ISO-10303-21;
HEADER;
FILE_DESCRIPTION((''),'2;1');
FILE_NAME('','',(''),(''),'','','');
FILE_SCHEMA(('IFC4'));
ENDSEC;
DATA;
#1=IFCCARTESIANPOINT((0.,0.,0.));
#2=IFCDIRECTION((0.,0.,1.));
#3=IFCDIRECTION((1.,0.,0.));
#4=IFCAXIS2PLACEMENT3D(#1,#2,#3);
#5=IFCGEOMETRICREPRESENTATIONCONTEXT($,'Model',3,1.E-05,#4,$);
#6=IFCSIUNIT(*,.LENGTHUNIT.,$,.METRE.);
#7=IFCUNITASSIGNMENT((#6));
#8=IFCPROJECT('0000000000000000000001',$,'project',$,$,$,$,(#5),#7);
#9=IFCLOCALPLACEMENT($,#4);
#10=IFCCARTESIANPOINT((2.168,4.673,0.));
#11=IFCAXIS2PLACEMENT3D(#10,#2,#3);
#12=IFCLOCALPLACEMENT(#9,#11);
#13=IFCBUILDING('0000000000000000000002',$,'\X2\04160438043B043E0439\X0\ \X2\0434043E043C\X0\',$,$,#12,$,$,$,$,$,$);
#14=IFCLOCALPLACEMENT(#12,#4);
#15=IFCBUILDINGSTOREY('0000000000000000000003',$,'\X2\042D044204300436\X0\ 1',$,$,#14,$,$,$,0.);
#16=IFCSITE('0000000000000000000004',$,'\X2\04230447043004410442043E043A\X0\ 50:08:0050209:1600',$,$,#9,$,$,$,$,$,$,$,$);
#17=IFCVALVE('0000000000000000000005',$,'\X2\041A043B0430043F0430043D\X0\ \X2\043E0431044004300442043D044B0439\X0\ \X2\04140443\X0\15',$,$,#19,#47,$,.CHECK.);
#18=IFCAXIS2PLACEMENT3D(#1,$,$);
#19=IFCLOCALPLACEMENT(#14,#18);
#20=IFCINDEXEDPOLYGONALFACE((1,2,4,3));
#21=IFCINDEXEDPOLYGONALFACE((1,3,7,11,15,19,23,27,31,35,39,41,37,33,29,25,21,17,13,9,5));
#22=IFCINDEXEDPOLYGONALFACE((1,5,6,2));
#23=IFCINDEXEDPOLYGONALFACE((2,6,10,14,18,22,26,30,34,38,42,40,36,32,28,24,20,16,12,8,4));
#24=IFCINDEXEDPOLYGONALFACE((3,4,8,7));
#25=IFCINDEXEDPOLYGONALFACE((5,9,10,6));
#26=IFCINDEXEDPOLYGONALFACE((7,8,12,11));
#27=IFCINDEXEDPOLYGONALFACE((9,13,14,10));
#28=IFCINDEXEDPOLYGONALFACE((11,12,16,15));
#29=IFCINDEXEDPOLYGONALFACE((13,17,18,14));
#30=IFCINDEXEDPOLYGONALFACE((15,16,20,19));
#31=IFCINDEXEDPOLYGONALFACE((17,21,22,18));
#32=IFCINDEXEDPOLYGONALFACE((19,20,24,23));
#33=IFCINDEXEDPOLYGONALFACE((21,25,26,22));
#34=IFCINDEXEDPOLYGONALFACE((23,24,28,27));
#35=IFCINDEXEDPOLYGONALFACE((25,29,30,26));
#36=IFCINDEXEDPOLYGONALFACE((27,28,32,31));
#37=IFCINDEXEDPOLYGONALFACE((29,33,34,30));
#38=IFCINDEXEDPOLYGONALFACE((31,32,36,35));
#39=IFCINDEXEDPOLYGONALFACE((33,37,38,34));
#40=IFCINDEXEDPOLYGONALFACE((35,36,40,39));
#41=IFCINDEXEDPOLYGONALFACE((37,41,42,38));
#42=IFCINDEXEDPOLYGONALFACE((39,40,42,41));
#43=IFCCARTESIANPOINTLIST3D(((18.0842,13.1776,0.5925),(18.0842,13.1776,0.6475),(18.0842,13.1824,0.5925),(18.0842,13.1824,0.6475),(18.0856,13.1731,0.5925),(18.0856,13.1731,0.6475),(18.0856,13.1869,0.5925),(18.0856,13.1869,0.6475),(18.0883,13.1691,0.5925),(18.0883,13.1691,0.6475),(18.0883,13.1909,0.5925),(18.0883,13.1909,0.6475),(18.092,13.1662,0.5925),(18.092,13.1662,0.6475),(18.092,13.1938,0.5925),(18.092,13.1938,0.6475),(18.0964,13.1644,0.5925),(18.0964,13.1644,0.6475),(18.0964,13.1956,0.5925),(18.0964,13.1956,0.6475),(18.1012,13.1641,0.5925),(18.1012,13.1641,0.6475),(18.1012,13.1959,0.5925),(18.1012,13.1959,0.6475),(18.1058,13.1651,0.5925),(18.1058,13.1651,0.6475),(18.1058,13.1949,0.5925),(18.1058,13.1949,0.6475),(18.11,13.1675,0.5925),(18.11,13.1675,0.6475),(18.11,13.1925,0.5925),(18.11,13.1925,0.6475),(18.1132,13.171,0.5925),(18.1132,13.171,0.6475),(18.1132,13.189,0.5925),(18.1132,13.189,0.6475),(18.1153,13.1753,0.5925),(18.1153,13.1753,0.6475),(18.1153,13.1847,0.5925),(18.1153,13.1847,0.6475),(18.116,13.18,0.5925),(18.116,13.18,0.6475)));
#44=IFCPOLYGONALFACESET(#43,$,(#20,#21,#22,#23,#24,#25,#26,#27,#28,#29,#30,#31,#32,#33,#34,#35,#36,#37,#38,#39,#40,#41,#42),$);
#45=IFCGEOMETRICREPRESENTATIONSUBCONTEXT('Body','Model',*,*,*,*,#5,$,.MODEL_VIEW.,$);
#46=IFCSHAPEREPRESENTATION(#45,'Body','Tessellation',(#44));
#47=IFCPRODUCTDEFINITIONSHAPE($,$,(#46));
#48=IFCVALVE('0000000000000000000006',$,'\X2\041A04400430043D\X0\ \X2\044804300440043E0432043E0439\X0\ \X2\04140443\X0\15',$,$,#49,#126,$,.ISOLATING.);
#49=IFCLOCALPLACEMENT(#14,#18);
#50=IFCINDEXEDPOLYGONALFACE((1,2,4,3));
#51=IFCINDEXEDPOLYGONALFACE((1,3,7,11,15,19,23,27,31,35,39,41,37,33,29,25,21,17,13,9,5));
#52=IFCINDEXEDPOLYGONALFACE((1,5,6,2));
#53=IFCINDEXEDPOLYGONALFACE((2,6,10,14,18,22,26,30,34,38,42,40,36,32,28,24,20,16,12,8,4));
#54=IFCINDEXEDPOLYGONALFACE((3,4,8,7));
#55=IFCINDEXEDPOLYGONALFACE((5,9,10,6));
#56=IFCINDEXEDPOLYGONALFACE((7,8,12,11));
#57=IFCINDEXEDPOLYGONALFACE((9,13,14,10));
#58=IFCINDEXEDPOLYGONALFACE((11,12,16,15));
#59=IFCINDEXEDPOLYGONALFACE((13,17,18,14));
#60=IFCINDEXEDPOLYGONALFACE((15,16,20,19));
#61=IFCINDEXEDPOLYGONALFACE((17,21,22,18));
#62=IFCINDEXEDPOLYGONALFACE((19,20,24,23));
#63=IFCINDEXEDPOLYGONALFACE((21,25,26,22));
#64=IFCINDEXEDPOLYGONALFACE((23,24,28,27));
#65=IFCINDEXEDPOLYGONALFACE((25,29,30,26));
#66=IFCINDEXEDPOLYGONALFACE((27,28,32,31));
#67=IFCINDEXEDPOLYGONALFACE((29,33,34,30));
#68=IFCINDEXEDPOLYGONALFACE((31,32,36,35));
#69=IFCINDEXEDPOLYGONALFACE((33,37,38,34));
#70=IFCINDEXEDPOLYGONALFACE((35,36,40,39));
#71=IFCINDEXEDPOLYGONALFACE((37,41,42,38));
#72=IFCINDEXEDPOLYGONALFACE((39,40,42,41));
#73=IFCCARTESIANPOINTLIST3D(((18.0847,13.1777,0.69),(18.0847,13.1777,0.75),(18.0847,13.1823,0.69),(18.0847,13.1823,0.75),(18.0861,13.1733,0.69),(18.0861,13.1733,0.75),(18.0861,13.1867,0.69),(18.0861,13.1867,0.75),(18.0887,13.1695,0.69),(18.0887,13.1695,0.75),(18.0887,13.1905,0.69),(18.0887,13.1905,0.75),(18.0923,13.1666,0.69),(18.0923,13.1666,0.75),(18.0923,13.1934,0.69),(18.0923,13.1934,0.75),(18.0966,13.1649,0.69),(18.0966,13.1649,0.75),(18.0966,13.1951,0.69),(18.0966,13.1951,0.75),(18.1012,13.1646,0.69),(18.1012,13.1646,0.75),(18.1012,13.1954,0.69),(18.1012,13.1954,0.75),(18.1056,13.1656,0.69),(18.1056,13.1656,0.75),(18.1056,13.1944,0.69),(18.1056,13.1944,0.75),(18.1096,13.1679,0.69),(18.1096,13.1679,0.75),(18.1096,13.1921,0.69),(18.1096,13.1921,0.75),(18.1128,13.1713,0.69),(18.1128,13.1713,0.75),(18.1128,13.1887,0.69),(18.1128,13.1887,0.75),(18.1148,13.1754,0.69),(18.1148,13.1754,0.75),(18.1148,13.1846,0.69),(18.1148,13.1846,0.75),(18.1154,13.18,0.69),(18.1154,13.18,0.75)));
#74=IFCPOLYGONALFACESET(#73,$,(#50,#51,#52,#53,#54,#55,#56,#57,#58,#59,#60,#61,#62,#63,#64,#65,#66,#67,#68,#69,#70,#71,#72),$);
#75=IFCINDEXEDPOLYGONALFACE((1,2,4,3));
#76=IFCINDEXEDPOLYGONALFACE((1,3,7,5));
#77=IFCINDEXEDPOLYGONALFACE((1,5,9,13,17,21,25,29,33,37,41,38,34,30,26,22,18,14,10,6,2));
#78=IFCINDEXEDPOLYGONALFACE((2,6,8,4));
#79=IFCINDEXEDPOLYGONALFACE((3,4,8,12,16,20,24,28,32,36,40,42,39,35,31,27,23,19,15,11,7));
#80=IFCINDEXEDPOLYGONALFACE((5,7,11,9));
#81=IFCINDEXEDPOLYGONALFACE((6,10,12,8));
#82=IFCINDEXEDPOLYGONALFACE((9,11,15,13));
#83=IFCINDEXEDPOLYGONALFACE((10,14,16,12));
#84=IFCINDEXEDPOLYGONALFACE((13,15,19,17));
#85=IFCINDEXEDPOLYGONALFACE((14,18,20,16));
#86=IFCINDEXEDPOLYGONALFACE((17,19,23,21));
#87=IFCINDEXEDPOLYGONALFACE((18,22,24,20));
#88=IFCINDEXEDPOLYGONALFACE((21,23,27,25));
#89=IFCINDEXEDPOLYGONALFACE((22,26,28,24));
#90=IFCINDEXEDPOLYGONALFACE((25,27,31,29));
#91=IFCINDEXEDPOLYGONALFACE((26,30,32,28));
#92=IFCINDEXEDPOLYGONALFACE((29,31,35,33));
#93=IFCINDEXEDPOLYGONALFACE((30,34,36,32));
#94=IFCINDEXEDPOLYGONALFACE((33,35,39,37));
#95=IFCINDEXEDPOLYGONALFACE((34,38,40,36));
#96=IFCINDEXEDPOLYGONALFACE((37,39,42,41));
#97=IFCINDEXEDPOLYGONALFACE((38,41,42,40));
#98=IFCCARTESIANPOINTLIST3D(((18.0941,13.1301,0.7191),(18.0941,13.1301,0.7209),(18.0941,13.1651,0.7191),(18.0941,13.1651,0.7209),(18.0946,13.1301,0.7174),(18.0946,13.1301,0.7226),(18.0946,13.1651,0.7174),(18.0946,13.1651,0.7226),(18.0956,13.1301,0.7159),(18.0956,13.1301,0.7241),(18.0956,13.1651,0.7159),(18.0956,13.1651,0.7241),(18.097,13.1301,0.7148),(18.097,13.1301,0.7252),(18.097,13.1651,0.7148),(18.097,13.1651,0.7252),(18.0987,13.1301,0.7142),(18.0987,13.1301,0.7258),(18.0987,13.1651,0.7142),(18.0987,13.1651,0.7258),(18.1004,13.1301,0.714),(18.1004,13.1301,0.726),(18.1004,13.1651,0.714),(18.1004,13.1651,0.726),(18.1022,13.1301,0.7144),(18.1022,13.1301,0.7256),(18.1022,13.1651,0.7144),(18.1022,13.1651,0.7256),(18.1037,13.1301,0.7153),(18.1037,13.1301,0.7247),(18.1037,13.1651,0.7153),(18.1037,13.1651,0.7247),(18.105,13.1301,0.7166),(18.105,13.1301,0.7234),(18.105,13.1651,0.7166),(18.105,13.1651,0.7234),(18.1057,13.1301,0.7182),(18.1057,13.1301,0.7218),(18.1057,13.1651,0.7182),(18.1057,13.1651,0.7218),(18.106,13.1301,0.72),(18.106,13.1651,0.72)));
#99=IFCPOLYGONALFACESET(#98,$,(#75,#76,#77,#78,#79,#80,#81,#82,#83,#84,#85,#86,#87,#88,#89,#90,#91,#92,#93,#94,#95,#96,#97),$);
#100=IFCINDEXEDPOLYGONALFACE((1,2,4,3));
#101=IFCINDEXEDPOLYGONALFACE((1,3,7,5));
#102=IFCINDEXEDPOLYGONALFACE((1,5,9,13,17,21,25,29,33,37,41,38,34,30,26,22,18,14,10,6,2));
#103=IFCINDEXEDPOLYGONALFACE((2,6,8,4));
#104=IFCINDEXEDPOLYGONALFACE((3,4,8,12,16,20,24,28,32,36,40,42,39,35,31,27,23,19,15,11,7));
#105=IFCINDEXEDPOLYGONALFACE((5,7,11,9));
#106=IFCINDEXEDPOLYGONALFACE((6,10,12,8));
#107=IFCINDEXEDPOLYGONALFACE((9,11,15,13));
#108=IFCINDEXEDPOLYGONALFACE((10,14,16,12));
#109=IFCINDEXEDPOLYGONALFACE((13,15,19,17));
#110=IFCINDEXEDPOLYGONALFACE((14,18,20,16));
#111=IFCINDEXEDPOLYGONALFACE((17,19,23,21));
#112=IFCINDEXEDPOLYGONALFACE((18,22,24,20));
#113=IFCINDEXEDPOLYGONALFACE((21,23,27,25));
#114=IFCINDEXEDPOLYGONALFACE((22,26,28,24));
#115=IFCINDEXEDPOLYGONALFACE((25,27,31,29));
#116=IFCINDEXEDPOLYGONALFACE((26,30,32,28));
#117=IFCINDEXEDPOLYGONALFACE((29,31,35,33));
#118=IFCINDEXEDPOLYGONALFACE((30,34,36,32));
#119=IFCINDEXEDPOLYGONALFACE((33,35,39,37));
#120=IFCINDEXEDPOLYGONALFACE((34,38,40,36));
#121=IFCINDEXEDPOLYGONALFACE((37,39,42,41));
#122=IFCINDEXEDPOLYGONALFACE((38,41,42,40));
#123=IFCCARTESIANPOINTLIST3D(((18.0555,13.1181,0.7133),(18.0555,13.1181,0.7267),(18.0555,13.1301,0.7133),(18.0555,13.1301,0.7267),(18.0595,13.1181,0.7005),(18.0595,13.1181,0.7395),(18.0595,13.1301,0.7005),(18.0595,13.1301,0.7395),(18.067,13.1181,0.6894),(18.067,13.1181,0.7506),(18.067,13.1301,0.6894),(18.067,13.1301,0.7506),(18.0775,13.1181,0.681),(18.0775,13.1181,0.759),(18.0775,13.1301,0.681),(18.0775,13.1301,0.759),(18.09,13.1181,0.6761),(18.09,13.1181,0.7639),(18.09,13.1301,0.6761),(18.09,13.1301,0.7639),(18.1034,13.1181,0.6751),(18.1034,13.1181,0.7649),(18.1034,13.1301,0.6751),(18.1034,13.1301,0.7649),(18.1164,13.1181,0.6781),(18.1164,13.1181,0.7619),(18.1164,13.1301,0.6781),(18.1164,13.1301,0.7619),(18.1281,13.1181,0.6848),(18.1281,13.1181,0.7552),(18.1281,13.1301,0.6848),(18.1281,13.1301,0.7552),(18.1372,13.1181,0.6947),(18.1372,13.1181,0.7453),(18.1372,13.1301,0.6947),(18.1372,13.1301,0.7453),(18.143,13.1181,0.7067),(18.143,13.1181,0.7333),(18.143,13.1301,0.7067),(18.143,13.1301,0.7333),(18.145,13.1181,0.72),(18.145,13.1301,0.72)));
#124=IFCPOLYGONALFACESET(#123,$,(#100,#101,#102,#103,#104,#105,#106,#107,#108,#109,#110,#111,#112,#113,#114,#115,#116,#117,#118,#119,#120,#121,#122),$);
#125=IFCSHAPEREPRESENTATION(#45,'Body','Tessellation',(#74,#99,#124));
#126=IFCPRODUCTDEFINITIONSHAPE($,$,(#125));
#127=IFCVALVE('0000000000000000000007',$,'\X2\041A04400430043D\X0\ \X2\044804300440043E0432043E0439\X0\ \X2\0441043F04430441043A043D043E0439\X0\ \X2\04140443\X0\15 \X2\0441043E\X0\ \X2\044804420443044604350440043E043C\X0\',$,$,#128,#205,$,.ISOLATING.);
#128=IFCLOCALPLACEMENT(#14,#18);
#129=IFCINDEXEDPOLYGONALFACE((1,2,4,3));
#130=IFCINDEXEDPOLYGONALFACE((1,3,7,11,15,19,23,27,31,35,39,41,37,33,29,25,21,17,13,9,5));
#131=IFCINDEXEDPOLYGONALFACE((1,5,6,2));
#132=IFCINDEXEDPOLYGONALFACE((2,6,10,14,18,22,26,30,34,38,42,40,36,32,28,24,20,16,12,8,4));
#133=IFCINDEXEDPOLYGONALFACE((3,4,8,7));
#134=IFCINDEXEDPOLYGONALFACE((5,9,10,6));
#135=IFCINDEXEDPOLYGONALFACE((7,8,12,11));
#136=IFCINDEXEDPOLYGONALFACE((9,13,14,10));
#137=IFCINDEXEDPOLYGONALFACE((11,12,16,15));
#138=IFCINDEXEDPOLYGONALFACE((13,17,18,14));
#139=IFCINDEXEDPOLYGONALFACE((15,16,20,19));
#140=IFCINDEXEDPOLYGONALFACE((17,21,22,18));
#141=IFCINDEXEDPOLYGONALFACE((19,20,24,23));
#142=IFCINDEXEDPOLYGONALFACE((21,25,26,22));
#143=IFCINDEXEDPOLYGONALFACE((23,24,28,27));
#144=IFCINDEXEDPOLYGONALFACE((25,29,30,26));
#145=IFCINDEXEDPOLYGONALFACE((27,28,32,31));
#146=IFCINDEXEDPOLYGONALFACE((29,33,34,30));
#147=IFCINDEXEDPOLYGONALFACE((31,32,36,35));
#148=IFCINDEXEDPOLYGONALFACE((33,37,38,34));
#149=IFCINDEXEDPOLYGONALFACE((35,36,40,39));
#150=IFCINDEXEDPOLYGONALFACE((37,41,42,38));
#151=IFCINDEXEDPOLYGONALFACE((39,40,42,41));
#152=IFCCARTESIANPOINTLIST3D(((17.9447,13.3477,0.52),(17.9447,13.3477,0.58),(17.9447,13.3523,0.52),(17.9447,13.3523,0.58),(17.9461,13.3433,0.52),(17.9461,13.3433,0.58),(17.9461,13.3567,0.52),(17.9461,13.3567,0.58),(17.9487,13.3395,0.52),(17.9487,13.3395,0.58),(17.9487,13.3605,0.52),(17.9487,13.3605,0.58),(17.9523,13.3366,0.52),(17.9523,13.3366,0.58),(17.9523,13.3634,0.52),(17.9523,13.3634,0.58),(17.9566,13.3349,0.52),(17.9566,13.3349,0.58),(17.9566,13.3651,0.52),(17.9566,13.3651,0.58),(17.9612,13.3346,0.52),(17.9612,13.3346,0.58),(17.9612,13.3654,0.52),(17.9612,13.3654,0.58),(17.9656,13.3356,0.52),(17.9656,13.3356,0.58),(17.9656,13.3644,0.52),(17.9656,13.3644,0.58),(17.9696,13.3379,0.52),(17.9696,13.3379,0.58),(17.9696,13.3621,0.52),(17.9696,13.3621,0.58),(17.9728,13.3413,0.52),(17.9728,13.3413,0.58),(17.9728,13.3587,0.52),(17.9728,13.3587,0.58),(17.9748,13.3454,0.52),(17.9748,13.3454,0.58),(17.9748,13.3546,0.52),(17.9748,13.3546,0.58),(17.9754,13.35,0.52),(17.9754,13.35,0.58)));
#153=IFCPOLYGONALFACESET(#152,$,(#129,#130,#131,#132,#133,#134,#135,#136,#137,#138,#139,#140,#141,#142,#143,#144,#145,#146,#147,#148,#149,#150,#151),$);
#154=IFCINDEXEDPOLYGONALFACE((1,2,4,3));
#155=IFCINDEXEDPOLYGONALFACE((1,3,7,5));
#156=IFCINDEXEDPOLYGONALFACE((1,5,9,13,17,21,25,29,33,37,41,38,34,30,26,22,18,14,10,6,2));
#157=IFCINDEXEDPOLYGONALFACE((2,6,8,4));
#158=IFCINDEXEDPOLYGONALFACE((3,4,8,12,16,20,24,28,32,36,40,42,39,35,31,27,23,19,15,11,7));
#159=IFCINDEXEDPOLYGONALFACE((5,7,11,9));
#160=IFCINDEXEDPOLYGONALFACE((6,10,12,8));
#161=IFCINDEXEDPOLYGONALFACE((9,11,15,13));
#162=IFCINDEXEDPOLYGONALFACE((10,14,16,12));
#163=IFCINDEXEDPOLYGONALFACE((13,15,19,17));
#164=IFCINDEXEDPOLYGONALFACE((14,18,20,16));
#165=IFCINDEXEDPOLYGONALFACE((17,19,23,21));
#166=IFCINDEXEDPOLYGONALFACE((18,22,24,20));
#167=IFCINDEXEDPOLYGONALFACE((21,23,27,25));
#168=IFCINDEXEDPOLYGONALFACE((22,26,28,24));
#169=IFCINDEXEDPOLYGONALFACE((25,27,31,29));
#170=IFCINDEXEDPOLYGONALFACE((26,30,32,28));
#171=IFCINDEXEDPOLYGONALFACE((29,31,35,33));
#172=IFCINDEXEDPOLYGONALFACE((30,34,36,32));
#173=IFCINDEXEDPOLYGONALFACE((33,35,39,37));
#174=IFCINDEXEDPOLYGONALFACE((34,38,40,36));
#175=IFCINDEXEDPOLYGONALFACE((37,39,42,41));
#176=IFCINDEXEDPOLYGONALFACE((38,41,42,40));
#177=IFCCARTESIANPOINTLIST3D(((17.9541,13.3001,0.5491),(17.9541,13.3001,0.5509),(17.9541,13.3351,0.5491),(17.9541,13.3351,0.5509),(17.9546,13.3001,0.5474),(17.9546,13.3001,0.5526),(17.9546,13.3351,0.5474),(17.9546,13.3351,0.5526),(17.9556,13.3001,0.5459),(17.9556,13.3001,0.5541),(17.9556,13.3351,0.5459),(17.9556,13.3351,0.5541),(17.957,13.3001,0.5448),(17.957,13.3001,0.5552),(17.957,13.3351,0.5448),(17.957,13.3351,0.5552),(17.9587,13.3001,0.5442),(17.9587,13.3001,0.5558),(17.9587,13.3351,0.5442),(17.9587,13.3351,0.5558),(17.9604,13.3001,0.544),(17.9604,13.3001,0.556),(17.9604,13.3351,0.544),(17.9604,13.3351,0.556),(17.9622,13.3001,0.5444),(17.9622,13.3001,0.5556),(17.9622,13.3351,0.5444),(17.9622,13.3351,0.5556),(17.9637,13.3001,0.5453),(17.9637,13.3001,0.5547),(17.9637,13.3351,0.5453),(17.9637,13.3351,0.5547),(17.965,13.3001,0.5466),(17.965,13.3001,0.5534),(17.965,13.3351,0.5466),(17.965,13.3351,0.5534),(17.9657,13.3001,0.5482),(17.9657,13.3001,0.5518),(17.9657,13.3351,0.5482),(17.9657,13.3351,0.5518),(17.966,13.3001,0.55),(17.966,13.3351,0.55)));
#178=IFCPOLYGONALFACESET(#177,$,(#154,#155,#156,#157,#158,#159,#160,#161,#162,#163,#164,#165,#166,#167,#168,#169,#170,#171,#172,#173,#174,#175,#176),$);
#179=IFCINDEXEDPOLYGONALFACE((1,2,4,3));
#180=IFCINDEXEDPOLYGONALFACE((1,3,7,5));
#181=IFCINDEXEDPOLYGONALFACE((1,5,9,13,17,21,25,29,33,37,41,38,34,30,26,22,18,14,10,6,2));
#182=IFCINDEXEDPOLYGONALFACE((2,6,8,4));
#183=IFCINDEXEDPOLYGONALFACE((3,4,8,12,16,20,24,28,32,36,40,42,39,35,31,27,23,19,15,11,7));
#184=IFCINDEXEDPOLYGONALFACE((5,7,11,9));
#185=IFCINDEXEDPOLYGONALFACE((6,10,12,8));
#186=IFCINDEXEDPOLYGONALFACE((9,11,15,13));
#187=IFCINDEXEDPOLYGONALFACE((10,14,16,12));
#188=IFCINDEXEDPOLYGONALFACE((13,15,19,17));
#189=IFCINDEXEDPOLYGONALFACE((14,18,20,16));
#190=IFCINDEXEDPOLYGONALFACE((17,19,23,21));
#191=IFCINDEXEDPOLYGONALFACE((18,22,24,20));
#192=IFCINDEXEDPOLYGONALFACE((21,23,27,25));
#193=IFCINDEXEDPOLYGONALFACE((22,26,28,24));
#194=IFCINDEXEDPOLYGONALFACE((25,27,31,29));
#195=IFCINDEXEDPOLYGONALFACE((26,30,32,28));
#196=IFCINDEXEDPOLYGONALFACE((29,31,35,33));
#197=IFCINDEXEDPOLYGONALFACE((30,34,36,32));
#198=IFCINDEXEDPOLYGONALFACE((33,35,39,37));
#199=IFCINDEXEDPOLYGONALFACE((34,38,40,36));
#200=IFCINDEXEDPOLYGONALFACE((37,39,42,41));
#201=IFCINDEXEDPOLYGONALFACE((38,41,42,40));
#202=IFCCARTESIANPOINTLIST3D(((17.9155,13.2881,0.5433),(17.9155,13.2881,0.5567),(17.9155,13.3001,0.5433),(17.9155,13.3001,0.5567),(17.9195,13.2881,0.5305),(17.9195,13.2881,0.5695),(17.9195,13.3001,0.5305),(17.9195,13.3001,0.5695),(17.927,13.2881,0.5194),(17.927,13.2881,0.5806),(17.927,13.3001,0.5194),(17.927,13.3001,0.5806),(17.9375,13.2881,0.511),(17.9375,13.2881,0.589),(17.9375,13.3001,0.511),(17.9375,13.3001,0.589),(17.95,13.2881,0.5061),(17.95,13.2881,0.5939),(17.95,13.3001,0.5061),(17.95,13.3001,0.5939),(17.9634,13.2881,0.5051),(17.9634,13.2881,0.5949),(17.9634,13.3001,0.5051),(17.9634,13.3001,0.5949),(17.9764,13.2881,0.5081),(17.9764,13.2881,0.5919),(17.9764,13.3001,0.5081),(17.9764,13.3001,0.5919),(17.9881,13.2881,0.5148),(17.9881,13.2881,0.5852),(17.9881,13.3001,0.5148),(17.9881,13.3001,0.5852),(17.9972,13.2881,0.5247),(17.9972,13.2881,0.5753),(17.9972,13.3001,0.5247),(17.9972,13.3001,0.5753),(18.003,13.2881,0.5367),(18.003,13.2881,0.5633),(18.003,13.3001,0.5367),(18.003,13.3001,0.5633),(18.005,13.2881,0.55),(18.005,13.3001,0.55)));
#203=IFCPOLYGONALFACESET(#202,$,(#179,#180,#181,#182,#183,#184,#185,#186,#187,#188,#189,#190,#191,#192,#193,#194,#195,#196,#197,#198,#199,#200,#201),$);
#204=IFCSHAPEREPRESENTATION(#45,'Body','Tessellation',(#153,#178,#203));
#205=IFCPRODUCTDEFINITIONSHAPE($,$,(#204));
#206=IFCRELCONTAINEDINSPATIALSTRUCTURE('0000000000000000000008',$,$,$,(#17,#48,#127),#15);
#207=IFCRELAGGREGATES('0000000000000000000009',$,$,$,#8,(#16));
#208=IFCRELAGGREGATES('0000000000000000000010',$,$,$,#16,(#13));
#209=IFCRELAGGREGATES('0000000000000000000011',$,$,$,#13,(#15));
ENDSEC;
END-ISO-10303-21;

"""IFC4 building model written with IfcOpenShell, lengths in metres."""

from ifc_helpers import new_model, si_unit, frame, origin_with_axes, origin_2d, place, context, subcontext, project, spatial, circle, extrude, element, save


model = new_model("IFC4")

# Units and contexts
model_context = context("Model", 3, precision=1e-05, world=origin_with_axes())
body_context = subcontext(model_context, "Body", "Model", "MODEL_VIEW")
ifc_project = project(units=[si_unit("LENGTHUNIT", "METRE")], contexts=[model_context])

# Site, building, storey
site_placement = place(None, origin_with_axes())
site = spatial("IfcSite", under=ifc_project, at=site_placement, Name="Участок 50:08:0050209:1600")
building_placement = place(site_placement, frame((2.168, 4.673, 0.0), z_axis=(0.0, 0.0, 1.0), x_axis=(1.0, 0.0, 0.0)))
building = spatial("IfcBuilding", under=site, at=building_placement, Name="Жилой дом")
storey_placement = place(building_placement, origin_with_axes())
storey = spatial("IfcBuildingStorey", under=building, at=storey_placement, Name="Этаж 1", Elevation=0.0)

# Valves
valve_1_placement = place(storey_placement, origin_with_axes())
element("IfcValve", 1, at=valve_1_placement, inside=storey, Name="Клапан обратный Ду15", PredefinedType="CHECK", context=body_context, shape_type="SweptSolid", body=[
    extrude(circle(Radius=0.016, at=origin_2d()), frame((18.1, 13.18, 0.5925), z_axis=(0.0, 0.0, 1.0), x_axis=(1.0, 0.0, 0.0)), (0.0, 0.0, 1.0), 0.055),
])
valve_2_placement = place(storey_placement, origin_with_axes())
element("IfcValve", 2, at=valve_2_placement, inside=storey, Name="Кран шаровой Ду15", PredefinedType="ISOLATING", context=body_context, shape_type="SweptSolid", body=[
    extrude(circle(Radius=0.0154, at=origin_2d()), frame((18.1, 13.18, 0.69), z_axis=(0.0, 0.0, 1.0), x_axis=(1.0, 0.0, 0.0)), (0.0, 0.0, 1.0), 0.06),
    extrude(circle(Radius=0.006, at=origin_2d()), frame((18.1, 13.1651, 0.72), z_axis=(0.0, -1.0, 0.0), x_axis=(1.0, 0.0, 0.0)), (0.0, 0.0, 1.0), 0.035),
    extrude(circle(Radius=0.045, at=origin_2d()), frame((18.1, 13.1301, 0.72), z_axis=(0.0, -1.0, 0.0), x_axis=(1.0, 0.0, 0.0)), (0.0, 0.0, 1.0), 0.012),
])
valve_3_placement = place(storey_placement, origin_with_axes())
element("IfcValve", 3, at=valve_3_placement, inside=storey, Name="Кран шаровой спускной Ду15 со штуцером", PredefinedType="ISOLATING", context=body_context, shape_type="SweptSolid", body=[
    extrude(circle(Radius=0.0154, at=origin_2d()), frame((17.96, 13.35, 0.52), z_axis=(0.0, 0.0, 1.0), x_axis=(1.0, 0.0, 0.0)), (0.0, 0.0, 1.0), 0.06),
    extrude(circle(Radius=0.006, at=origin_2d()), frame((17.96, 13.3351, 0.55), z_axis=(0.0, -1.0, 0.0), x_axis=(1.0, 0.0, 0.0)), (0.0, 0.0, 1.0), 0.035),
    extrude(circle(Radius=0.045, at=origin_2d()), frame((17.96, 13.3001, 0.55), z_axis=(0.0, -1.0, 0.0), x_axis=(1.0, 0.0, 0.0)), (0.0, 0.0, 1.0), 0.012),
])

save(model, "model.ifc")
